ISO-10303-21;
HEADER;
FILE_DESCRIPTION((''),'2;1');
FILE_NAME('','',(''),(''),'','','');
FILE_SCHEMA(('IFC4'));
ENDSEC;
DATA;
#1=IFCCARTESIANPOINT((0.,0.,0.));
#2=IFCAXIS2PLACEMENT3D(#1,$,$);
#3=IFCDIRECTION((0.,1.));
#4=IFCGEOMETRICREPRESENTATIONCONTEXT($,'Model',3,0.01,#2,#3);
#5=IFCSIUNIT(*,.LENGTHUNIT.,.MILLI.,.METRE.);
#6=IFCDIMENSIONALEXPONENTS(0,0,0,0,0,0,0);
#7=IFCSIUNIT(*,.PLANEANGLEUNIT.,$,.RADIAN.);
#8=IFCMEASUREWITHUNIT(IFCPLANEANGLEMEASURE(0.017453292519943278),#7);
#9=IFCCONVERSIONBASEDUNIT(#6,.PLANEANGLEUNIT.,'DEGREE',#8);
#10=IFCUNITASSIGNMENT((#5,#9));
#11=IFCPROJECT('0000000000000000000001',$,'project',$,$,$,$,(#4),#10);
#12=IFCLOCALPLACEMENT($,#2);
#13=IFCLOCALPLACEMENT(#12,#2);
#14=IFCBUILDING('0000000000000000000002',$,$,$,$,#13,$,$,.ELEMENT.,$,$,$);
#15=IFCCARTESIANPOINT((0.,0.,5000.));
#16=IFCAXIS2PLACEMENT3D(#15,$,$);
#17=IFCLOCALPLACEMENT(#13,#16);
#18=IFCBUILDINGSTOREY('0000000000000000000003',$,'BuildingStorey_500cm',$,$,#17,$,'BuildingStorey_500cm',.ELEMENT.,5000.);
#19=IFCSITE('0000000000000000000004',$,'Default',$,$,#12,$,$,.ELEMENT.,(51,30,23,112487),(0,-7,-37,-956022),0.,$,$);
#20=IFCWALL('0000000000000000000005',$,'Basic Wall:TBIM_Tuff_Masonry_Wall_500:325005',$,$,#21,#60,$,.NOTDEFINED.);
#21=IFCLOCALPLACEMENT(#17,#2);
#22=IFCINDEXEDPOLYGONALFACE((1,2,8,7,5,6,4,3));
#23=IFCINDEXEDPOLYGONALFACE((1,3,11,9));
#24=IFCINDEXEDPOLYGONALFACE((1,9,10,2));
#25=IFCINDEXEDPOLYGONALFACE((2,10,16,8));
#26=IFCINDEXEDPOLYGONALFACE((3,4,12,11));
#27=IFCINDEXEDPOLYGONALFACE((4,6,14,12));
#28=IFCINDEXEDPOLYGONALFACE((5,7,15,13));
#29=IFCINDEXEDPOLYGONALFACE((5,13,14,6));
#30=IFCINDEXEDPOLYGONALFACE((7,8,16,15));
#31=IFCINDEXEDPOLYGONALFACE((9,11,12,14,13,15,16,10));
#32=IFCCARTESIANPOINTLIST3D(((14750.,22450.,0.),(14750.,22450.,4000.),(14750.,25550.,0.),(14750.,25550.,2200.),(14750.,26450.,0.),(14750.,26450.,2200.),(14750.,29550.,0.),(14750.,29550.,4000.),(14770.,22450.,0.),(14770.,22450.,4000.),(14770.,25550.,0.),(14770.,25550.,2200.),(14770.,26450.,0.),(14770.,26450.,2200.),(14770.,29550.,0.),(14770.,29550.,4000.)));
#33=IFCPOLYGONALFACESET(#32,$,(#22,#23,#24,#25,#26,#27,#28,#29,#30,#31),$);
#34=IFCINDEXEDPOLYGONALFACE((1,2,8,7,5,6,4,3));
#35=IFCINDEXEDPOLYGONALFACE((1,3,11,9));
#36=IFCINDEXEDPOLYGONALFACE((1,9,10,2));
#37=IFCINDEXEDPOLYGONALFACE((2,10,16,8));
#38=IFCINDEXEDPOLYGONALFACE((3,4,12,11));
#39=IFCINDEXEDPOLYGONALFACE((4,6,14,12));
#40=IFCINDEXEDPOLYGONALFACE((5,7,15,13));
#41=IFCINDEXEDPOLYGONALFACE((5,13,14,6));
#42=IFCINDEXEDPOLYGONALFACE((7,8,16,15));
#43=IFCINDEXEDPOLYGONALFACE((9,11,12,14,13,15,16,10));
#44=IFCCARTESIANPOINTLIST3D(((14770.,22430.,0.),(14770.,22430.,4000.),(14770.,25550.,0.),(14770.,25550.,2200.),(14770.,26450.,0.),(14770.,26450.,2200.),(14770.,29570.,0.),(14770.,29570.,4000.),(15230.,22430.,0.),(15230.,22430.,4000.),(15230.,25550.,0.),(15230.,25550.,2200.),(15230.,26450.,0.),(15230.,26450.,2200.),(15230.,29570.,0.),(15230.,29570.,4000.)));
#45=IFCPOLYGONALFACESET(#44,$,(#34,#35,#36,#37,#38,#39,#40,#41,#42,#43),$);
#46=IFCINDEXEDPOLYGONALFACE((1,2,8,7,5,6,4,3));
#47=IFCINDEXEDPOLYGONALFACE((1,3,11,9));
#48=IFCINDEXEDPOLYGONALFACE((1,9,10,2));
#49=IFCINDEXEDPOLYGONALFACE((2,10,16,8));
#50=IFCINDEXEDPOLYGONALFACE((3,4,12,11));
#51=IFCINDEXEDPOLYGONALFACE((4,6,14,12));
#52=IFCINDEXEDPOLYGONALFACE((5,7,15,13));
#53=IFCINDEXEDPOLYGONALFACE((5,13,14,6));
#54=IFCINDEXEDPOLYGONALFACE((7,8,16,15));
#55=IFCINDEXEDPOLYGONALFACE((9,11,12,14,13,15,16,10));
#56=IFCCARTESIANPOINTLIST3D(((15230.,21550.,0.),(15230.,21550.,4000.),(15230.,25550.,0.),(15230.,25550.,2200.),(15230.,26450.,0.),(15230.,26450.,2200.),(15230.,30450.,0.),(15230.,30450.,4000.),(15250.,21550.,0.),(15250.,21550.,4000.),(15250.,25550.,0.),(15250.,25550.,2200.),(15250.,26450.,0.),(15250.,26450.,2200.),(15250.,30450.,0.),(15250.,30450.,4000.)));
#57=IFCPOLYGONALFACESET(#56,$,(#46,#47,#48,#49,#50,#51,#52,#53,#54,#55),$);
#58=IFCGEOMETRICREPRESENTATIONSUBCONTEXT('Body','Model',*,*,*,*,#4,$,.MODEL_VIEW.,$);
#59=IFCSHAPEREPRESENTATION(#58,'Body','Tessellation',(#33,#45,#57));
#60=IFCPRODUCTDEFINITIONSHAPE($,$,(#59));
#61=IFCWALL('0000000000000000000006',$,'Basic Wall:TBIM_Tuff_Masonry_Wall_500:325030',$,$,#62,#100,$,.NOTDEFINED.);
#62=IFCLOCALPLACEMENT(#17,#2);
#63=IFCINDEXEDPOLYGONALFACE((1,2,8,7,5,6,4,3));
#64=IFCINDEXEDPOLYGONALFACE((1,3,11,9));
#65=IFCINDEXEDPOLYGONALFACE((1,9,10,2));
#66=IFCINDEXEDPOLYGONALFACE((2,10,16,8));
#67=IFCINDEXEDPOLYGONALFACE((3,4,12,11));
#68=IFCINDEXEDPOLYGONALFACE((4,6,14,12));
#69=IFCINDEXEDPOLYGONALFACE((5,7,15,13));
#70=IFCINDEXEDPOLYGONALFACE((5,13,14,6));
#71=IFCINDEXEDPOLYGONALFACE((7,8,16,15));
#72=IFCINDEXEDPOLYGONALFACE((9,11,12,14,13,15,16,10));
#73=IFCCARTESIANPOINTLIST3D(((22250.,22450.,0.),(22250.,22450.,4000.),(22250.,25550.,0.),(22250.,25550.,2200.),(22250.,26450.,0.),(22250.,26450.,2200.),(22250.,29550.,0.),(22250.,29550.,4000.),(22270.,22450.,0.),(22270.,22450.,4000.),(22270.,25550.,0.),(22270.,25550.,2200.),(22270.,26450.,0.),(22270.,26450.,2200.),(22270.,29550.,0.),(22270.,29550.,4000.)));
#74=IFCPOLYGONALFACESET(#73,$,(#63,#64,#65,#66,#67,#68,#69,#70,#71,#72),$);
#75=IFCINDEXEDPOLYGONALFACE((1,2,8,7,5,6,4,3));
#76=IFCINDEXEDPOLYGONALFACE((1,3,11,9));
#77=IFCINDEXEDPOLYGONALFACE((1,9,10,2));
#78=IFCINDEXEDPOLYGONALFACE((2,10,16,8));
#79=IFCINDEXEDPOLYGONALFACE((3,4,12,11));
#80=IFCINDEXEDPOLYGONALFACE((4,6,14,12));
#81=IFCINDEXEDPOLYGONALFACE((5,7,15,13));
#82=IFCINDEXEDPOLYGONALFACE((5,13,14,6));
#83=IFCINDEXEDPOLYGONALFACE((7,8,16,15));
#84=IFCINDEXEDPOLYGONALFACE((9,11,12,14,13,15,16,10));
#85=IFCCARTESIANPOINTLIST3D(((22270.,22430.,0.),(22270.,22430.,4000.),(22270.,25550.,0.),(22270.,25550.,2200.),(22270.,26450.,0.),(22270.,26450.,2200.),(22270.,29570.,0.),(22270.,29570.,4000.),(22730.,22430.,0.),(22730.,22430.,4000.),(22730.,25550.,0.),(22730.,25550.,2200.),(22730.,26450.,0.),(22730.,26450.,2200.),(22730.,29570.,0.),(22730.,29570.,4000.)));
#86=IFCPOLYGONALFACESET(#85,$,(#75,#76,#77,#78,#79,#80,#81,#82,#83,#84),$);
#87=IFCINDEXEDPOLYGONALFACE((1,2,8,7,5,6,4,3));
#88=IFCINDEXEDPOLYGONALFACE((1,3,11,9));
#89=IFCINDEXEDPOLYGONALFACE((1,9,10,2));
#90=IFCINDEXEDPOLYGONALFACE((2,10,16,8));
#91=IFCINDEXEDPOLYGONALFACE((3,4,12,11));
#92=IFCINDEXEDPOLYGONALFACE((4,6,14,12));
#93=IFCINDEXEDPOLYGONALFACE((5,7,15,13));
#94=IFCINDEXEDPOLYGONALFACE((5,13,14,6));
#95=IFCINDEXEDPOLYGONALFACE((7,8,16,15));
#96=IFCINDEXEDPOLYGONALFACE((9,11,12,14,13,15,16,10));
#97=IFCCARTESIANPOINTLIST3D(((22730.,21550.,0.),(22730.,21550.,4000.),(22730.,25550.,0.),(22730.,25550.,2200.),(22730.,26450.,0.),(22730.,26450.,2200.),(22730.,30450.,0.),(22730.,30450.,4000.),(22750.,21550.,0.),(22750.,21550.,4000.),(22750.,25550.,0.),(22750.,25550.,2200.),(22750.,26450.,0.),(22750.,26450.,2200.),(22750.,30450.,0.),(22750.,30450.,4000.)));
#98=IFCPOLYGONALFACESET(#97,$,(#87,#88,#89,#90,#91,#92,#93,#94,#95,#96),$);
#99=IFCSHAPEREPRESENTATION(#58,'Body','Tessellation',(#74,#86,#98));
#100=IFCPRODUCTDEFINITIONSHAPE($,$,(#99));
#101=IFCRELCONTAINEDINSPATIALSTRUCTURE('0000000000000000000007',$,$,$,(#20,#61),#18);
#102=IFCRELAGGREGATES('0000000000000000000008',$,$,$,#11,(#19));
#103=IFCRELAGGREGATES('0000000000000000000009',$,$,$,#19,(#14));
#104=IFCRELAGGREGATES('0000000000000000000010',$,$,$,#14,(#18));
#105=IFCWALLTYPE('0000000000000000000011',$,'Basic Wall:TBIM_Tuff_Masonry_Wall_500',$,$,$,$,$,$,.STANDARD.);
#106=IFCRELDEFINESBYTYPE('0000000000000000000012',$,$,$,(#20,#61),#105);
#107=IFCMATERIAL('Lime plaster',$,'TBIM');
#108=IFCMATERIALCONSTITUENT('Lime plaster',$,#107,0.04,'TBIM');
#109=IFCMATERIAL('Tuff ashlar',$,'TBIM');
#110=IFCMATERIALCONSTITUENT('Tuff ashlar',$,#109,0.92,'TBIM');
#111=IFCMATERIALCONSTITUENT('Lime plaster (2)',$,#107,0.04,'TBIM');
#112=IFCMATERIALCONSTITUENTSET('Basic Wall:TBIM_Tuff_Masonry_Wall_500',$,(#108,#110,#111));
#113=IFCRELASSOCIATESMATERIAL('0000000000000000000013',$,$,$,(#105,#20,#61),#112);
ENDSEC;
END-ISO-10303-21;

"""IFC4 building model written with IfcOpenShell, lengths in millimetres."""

from ifc_helpers import new_model, entity, si_unit, converted_unit, direction, frame, origin, place, context, subcontext, project, spatial, indexed_curve, outline, extrude, material, constituent, constituent_set, type_object, element, save


model = new_model("IFC4")

# Units and contexts
model_context = context("Model", 3, precision=0.01, world=origin(), true_north=direction((0.0, 1.0)))
body_context = subcontext(model_context, "Body", "Model", "MODEL_VIEW")
ifc_project = project(units=[si_unit("LENGTHUNIT", "METRE", prefix="MILLI"), converted_unit("PLANEANGLEUNIT", "DEGREE", entity("IfcPlaneAngleMeasure", 0.017453292519943278), si_unit("PLANEANGLEUNIT", "RADIAN"), dimensions=[0, 0, 0, 0, 0, 0, 0])], contexts=[model_context])

# Site, building, storey
site_placement = place(None, origin())
site = spatial("IfcSite", under=ifc_project, at=site_placement, Name="Default", CompositionType="ELEMENT", RefLatitude=(51, 30, 23, 112487), RefLongitude=(0, -7, -37, -956022), RefElevation=0.0)
building_placement = place(site_placement, origin())
building = spatial("IfcBuilding", under=site, at=building_placement, CompositionType="ELEMENT")
storey_placement = place(building_placement, frame((0.0, 0.0, 5000.0)))
storey = spatial("IfcBuildingStorey", under=building, at=storey_placement, Name="BuildingStorey_500cm", LongName="BuildingStorey_500cm", CompositionType="ELEMENT", Elevation=5000.0)

# Shared definitions
ifc_material_1 = material(Name="Tuff ashlar", Category="TBIM")
ifc_material_2 = material(Name="Lime plaster", Category="TBIM")

# Walls, openings
ifc_constituent_1 = constituent(ifc_material_2, Name="Lime plaster", Category="TBIM", fraction=0.04)
ifc_constituent_2 = constituent(ifc_material_1, Name="Tuff ashlar", Category="TBIM", fraction=0.92)
ifc_constituent_3 = constituent(ifc_material_2, Name="Lime plaster (2)", Category="TBIM", fraction=0.04)
ifc_constituent_set_1 = constituent_set(constituents=[ifc_constituent_1, ifc_constituent_2, ifc_constituent_3], Name="Basic Wall:TBIM_Tuff_Masonry_Wall_500")
wall_type_1 = type_object("IfcWallType", Name="Basic Wall:TBIM_Tuff_Masonry_Wall_500", PredefinedType="STANDARD", material=ifc_constituent_set_1)
wall_1_placement = place(storey_placement, frame((15000.0, 22450.0, 0.0), z_axis=(0.0, 0.0, 1.0), x_axis=(0.0, 1.0, 0.0)))
wall_1 = element("IfcWall", 1, at=wall_1_placement, inside=storey, type_object=wall_type_1, material=ifc_constituent_set_1, Name="Basic Wall:TBIM_Tuff_Masonry_Wall_500:325005", PredefinedType="NOTDEFINED", context=body_context, shape_type="SweptSolid", body=[
    extrude(outline(indexed_curve([(-2450.0, -3550.0), (1550.0, -3550.0), (1550.0, -450.0), (-650.0, -450.0), (-650.0, 450.0), (1550.0, 450.0), (1550.0, 3550.0), (-2450.0, 3550.0), (-2450.0, -3550.0)], self_intersect=False)), frame((3550.0, 250.0, 1550.0), z_axis=(0.0, -1.0, 0.0), x_axis=(0.0, 0.0, -1.0)), (0.0, 0.0, 1.0), 20.0),
    extrude(outline(indexed_curve([(-1550.0, -450.0), (-1550.0, -3570.0), (2450.0, -3570.0), (2450.0, 3570.0), (-1550.0, 3570.0), (-1550.0, 450.0), (650.0, 450.0), (650.0, -450.0), (-1550.0, -450.0)], self_intersect=False)), frame((3550.0, 230.0, 1550.0), z_axis=(0.0, 1.0, 0.0), x_axis=(0.0, 0.0, 1.0)), (0.0, 0.0, -1.0), 460.0),
    extrude(outline(indexed_curve([(-1550.0, -450.0), (-1550.0, -4450.0), (2450.0, -4450.0), (2450.0, 4450.0), (-1550.0, 4450.0), (-1550.0, 450.0), (650.0, 450.0), (650.0, -450.0), (-1550.0, -450.0)], self_intersect=False)), frame((3550.0, -230.0, 1550.0), z_axis=(0.0, 1.0, 0.0), x_axis=(0.0, 0.0, 1.0)), (0.0, 0.0, -1.0), 20.0),
])
opening_1_placement = place(wall_1_placement, frame((3100.0, -250.0, 0.0)))
element("IfcOpeningElement", 2, at=opening_1_placement, cuts=wall_1, PredefinedType="OPENING", context=body_context, shape_type="SweptSolid", body=[
    extrude(outline(indexed_curve([(0.0, 900.0), (0.0, 0.0), (2200.0, 0.0), (2200.0, 900.0), (0.0, 900.0)], self_intersect=False)), frame((0.0, 0.0, 0.0), z_axis=(0.0, 1.0, 0.0), x_axis=(0.0, 0.0, 1.0)), (0.0, 0.0, 1.0), 500.0),
])
wall_2_placement = place(storey_placement, frame((22500.0, 22450.0, 0.0), z_axis=(0.0, 0.0, 1.0), x_axis=(0.0, 1.0, 0.0)))
wall_2 = element("IfcWall", 3, at=wall_2_placement, inside=storey, type_object=wall_type_1, material=ifc_constituent_set_1, Name="Basic Wall:TBIM_Tuff_Masonry_Wall_500:325030", PredefinedType="NOTDEFINED", context=body_context, shape_type="SweptSolid", body=[
    extrude(outline(indexed_curve([(-2450.0, -3550.0), (1550.0, -3550.0), (1550.0, -450.0), (-650.0, -450.0), (-650.0, 450.0), (1550.0, 450.0), (1550.0, 3550.0), (-2450.0, 3550.0), (-2450.0, -3550.0)], self_intersect=False)), frame((3550.0, 250.0, 1550.0), z_axis=(0.0, -1.0, 0.0), x_axis=(0.0, 0.0, -1.0)), (0.0, 0.0, 1.0), 20.0),
    extrude(outline(indexed_curve([(-1550.0, -450.0), (-1550.0, -3570.0), (2450.0, -3570.0), (2450.0, 3570.0), (-1550.0, 3570.0), (-1550.0, 450.0), (650.0, 450.0), (650.0, -450.0), (-1550.0, -450.0)], self_intersect=False)), frame((3550.0, 230.0, 1550.0), z_axis=(0.0, 1.0, 0.0), x_axis=(0.0, 0.0, 1.0)), (0.0, 0.0, -1.0), 460.0),
    extrude(outline(indexed_curve([(-1550.0, -450.0), (-1550.0, -4450.0), (2450.0, -4450.0), (2450.0, 4450.0), (-1550.0, 4450.0), (-1550.0, 450.0), (650.0, 450.0), (650.0, -450.0), (-1550.0, -450.0)], self_intersect=False)), frame((3550.0, -230.0, 1550.0), z_axis=(0.0, 1.0, 0.0), x_axis=(0.0, 0.0, 1.0)), (0.0, 0.0, -1.0), 20.0),
])
opening_2_placement = place(wall_2_placement, frame((3100.0, -250.0, 0.0)))
element("IfcOpeningElement", 4, at=opening_2_placement, cuts=wall_2, PredefinedType="OPENING", context=body_context, shape_type="SweptSolid", body=[
    extrude(outline(indexed_curve([(0.0, 900.0), (0.0, 0.0), (2200.0, 0.0), (2200.0, 900.0), (0.0, 900.0)], self_intersect=False)), frame((0.0, 0.0, 0.0), z_axis=(0.0, 1.0, 0.0), x_axis=(0.0, 0.0, 1.0)), (0.0, 0.0, 1.0), 500.0),
])

save(model, "model.ifc")
